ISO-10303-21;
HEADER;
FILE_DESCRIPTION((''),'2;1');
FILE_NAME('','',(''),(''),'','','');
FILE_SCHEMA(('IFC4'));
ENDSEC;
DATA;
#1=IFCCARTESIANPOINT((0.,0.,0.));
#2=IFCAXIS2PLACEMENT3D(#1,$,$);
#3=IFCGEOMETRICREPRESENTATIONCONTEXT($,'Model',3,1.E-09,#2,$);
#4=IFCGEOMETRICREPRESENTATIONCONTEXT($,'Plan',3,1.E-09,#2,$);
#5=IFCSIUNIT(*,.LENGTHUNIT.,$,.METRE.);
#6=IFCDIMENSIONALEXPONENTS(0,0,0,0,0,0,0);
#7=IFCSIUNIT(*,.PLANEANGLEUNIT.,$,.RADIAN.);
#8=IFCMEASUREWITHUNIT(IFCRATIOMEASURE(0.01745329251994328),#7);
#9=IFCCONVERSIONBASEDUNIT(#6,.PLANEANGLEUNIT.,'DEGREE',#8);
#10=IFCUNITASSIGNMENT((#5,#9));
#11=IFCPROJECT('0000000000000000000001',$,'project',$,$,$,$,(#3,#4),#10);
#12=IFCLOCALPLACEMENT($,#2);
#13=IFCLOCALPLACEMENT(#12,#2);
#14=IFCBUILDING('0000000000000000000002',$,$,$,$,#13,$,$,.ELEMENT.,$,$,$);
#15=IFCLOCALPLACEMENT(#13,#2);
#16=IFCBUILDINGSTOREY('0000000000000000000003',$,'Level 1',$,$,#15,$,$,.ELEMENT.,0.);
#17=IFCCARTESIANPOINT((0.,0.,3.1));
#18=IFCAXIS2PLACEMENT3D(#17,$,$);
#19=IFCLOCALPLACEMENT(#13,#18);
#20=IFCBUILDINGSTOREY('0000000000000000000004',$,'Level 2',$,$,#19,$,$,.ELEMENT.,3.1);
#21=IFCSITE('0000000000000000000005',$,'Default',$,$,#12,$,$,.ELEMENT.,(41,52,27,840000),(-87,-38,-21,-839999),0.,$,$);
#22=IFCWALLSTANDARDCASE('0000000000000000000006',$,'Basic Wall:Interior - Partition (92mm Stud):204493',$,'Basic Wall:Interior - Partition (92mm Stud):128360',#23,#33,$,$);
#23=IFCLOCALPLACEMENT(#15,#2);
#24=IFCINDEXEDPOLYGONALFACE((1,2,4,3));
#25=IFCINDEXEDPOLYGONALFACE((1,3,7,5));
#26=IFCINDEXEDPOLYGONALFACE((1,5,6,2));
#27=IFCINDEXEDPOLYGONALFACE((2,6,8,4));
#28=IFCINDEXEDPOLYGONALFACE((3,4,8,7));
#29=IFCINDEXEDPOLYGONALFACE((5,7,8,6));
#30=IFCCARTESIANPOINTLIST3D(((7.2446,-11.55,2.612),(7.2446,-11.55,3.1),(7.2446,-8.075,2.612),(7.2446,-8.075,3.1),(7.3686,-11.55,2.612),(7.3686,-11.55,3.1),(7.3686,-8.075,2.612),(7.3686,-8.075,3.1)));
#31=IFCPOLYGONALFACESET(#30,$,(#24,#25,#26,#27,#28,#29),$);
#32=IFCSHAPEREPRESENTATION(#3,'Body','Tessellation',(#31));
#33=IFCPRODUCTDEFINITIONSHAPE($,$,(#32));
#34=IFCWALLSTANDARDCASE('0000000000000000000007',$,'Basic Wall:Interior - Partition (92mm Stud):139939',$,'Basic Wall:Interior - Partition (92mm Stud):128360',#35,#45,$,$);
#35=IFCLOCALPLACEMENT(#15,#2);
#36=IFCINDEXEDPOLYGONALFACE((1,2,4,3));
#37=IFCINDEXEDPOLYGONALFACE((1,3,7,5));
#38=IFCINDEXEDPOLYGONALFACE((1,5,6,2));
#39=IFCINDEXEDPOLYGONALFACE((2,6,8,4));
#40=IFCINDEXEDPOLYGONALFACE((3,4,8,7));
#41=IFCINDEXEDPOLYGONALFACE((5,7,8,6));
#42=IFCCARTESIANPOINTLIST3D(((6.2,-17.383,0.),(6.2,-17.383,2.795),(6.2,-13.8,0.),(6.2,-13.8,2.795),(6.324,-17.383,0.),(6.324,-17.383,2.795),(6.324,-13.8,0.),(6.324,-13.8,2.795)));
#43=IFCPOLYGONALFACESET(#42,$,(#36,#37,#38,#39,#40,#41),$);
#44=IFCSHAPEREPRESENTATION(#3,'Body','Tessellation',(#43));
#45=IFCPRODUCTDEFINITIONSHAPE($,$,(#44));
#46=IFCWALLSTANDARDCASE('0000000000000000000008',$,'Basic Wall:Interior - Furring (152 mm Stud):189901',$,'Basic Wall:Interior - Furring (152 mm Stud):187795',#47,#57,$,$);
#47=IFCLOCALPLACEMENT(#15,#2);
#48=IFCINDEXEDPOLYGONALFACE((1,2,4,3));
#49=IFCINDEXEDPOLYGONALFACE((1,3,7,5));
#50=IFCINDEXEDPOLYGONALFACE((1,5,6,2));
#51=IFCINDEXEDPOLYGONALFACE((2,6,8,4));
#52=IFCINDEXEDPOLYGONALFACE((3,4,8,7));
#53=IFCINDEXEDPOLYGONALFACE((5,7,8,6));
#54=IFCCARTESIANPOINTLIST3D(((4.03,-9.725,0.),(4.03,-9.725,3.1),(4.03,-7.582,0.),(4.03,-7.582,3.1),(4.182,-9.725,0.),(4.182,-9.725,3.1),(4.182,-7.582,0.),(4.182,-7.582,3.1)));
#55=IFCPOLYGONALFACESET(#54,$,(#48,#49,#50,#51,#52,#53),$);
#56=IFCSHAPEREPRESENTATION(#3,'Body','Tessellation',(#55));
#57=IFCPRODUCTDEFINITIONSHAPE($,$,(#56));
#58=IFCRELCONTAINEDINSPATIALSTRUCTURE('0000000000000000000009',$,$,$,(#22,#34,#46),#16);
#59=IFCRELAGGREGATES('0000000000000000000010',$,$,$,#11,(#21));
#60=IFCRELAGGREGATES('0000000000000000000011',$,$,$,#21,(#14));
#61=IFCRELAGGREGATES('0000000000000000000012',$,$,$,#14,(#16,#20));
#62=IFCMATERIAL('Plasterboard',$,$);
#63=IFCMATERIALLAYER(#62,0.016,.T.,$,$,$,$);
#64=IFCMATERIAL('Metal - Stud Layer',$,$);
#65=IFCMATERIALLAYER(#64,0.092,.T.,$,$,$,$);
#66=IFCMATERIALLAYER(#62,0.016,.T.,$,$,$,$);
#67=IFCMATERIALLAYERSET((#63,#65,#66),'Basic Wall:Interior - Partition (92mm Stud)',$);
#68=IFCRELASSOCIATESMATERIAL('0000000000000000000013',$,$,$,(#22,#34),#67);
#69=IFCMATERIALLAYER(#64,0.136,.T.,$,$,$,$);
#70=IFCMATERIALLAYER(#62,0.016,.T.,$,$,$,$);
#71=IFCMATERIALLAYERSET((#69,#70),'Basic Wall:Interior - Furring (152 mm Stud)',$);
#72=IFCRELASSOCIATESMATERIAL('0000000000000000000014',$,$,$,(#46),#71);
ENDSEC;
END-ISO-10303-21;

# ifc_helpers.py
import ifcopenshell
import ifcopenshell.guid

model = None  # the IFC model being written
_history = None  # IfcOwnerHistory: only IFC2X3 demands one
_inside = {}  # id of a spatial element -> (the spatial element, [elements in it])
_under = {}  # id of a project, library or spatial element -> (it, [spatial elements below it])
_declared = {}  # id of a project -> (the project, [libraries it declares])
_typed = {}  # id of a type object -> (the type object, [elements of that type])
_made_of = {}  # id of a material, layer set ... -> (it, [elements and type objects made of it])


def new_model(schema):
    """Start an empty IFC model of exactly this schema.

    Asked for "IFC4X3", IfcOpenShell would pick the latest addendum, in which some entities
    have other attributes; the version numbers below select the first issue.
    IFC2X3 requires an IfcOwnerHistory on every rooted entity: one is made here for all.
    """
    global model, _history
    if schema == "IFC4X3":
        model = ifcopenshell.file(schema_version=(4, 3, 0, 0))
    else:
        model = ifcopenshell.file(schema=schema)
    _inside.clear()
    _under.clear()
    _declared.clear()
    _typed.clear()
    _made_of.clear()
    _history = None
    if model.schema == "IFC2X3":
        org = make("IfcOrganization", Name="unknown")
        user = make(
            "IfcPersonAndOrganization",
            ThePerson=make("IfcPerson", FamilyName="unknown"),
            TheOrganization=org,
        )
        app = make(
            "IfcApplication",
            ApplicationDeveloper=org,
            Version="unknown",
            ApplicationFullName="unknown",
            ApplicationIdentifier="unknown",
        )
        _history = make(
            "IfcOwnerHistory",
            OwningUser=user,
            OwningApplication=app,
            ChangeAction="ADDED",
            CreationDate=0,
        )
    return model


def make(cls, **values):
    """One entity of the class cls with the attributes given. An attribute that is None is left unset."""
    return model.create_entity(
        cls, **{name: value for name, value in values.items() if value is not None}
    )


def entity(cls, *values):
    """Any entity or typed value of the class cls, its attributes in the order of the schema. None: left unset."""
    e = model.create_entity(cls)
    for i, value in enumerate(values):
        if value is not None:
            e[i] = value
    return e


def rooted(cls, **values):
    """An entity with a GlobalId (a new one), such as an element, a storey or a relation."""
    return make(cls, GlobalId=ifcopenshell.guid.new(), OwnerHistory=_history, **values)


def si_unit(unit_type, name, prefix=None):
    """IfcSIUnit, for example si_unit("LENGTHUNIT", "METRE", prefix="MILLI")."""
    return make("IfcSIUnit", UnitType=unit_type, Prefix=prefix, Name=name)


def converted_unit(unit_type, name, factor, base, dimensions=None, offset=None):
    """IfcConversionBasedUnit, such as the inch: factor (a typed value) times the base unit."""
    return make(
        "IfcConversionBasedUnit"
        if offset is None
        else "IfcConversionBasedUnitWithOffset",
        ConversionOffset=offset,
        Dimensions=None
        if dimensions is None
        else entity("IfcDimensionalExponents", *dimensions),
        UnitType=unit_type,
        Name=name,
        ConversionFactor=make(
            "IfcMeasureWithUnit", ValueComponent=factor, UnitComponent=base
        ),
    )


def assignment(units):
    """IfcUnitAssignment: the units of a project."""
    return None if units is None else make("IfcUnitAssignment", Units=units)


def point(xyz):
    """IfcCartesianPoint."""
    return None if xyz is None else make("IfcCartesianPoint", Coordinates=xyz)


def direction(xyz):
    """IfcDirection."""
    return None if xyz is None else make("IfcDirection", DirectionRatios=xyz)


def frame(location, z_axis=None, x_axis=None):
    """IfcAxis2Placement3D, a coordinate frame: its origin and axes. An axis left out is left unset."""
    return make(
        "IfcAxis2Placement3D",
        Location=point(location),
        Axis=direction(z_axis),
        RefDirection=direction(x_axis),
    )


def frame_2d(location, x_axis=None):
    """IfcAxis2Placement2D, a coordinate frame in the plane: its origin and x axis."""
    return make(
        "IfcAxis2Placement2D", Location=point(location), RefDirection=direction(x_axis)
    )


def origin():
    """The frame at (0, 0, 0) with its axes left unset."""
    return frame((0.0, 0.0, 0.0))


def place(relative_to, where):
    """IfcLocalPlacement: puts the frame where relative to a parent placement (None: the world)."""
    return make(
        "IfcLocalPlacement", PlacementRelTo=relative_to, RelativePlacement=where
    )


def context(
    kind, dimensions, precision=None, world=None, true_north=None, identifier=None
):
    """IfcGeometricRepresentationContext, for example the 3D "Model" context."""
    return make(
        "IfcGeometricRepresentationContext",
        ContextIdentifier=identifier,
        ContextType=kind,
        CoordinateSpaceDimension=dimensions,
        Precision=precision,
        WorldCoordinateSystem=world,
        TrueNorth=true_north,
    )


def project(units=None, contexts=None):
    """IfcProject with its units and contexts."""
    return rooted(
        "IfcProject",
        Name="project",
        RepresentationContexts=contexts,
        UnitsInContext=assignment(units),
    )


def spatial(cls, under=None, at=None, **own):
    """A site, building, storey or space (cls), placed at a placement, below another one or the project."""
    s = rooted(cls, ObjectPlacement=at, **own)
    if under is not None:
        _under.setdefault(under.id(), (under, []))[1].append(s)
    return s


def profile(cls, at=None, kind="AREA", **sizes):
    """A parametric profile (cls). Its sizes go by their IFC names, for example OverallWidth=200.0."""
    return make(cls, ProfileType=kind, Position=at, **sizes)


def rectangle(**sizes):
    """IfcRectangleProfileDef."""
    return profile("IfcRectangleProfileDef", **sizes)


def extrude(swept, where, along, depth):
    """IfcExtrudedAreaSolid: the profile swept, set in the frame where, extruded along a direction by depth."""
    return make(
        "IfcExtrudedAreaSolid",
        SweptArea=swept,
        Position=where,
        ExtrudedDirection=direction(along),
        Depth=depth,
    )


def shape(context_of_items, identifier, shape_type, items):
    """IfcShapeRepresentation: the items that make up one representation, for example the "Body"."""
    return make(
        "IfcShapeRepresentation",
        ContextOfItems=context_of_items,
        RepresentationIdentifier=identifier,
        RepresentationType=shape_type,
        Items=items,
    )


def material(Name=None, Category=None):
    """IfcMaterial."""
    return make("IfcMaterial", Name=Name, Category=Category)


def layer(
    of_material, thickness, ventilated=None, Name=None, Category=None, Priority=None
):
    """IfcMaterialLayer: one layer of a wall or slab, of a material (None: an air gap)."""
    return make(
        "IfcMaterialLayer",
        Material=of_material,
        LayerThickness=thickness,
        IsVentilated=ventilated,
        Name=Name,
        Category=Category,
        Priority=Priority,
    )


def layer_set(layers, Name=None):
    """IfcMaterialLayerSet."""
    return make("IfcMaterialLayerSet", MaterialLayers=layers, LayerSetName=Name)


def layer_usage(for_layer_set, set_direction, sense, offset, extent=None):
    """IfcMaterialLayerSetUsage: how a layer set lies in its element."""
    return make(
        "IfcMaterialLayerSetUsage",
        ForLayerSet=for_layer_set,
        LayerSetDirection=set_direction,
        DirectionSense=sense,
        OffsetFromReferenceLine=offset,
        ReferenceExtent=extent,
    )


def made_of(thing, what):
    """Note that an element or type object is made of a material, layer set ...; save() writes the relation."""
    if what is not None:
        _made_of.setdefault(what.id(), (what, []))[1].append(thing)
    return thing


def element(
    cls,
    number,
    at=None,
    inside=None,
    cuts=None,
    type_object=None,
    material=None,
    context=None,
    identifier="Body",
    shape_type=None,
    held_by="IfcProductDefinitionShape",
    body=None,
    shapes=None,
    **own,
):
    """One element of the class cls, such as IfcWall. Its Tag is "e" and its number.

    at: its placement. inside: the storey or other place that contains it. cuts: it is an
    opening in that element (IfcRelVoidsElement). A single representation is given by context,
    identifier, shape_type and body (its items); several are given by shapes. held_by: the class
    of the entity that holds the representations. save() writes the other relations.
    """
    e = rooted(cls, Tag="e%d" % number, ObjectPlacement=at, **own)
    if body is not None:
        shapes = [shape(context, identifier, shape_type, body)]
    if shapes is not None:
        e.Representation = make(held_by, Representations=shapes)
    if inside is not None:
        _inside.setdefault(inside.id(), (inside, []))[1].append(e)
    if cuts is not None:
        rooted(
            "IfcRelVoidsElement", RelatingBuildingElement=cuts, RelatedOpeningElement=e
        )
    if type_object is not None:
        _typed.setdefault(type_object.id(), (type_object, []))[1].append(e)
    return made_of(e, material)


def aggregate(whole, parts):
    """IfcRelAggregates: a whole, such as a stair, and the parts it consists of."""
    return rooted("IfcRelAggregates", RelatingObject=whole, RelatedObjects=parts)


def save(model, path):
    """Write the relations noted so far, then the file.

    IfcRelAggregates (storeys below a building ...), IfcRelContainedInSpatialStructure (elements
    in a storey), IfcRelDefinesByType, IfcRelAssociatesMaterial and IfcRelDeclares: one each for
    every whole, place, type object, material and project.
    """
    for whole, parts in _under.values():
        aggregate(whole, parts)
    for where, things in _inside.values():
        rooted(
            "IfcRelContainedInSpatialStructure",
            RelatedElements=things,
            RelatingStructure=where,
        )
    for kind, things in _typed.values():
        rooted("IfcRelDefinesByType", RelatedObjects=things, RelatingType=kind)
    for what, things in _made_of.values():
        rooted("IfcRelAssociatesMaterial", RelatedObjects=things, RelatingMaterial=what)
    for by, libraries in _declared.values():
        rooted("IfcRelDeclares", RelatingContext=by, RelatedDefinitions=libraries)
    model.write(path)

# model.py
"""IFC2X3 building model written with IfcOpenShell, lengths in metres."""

from ifc_helpers import new_model, entity, si_unit, converted_unit, frame, frame_2d, origin, place, context, project, spatial, rectangle, extrude, material, layer, layer_set, layer_usage, element, save


model = new_model("IFC2X3")

# Units and contexts
model_context = context("Model", 3, precision=1e-09, world=origin())
plan_context = context("Plan", 3, precision=1e-09, world=origin())
ifc_project = project(units=[si_unit("LENGTHUNIT", "METRE"), converted_unit("PLANEANGLEUNIT", "DEGREE", entity("IfcRatioMeasure", 0.01745329251994328), si_unit("PLANEANGLEUNIT", "RADIAN"), dimensions=[0, 0, 0, 0, 0, 0, 0])], contexts=[model_context, plan_context])

# Site, building, storey
site_placement = place(None, origin())
site = spatial("IfcSite", under=ifc_project, at=site_placement, Name="Default", CompositionType="ELEMENT", RefLatitude=(41, 52, 27, 840000), RefLongitude=(-87, -38, -21, -839999), RefElevation=0.0)
building_placement = place(site_placement, origin())
building = spatial("IfcBuilding", under=site, at=building_placement, CompositionType="ELEMENT")
storey_1_placement = place(building_placement, origin())
storey_1 = spatial("IfcBuildingStorey", under=building, at=storey_1_placement, Name="Level 1", CompositionType="ELEMENT", Elevation=0.0)

# Shared definitions
ifc_material_1 = material(Name="Metal - Stud Layer")
ifc_material_2 = material(Name="Plasterboard")

# Wall
ifc_layer_1 = layer(ifc_material_2, 0.016, ventilated=True)
ifc_layer_2 = layer(ifc_material_1, 0.092, ventilated=True)
ifc_layer_3 = layer(ifc_material_2, 0.016, ventilated=True)
ifc_layer_set_1 = layer_set([ifc_layer_1, ifc_layer_2, ifc_layer_3], Name="Basic Wall:Interior - Partition (92mm Stud)")
ifc_layer_usage_1 = layer_usage(ifc_layer_set_1, "AXIS2", "NEGATIVE", 0.062)
wall_1_placement = place(storey_1_placement, frame((7.3066, -11.55, 2.612), z_axis=(0.0, 0.0, 1.0), x_axis=(0.0, 1.0, 0.0)))
element("IfcWallStandardCase", 1, at=wall_1_placement, inside=storey_1, material=ifc_layer_usage_1, Name="Basic Wall:Interior - Partition (92mm Stud):204493", ObjectType="Basic Wall:Interior - Partition (92mm Stud):128360", context=model_context, shape_type="SweptSolid", body=[
    extrude(rectangle(XDim=3.475, YDim=0.124, at=frame_2d((1.7375, 0.0), x_axis=(-1.0, 0.0))), origin(), (0.0, 0.0, 1.0), 0.488),
])

# Shared definitions
storey_2_placement = place(building_placement, frame((0.0, 0.0, 3.1)))
storey_2 = spatial("IfcBuildingStorey", under=building, at=storey_2_placement, Name="Level 2", CompositionType="ELEMENT", Elevation=3.1)

# Walls
wall_2_placement = place(storey_1_placement, frame((6.262, -13.8, 0.0), z_axis=(0.0, 0.0, 1.0), x_axis=(0.0, -1.0, 0.0)))
element("IfcWallStandardCase", 2, at=wall_2_placement, inside=storey_1, material=ifc_layer_usage_1, Name="Basic Wall:Interior - Partition (92mm Stud):139939", ObjectType="Basic Wall:Interior - Partition (92mm Stud):128360", context=model_context, shape_type="SweptSolid", body=[
    extrude(rectangle(XDim=3.583, YDim=0.124, at=frame_2d((1.7915, 0.0), x_axis=(-1.0, 0.0))), origin(), (0.0, 0.0, 1.0), 2.795),
])
ifc_layer_4 = layer(ifc_material_1, 0.136, ventilated=True)
ifc_layer_5 = layer(ifc_material_2, 0.016, ventilated=True)
ifc_layer_set_2 = layer_set([ifc_layer_4, ifc_layer_5], Name="Basic Wall:Interior - Furring (152 mm Stud)")
ifc_layer_usage_2 = layer_usage(ifc_layer_set_2, "AXIS2", "POSITIVE", -0.076)
wall_3_placement = place(storey_1_placement, frame((4.106, -9.725, 0.0), z_axis=(0.0, 0.0, 1.0), x_axis=(0.0, 1.0, 0.0)))
element("IfcWallStandardCase", 3, at=wall_3_placement, inside=storey_1, material=ifc_layer_usage_2, Name="Basic Wall:Interior - Furring (152 mm Stud):189901", ObjectType="Basic Wall:Interior - Furring (152 mm Stud):187795", context=model_context, shape_type="SweptSolid", body=[
    extrude(rectangle(XDim=2.143, YDim=0.152, at=frame_2d((1.0715, 0.0), x_axis=(-1.0, 0.0))), origin(), (0.0, 0.0, 1.0), 3.1),
])

save(model, "model.ifc")
